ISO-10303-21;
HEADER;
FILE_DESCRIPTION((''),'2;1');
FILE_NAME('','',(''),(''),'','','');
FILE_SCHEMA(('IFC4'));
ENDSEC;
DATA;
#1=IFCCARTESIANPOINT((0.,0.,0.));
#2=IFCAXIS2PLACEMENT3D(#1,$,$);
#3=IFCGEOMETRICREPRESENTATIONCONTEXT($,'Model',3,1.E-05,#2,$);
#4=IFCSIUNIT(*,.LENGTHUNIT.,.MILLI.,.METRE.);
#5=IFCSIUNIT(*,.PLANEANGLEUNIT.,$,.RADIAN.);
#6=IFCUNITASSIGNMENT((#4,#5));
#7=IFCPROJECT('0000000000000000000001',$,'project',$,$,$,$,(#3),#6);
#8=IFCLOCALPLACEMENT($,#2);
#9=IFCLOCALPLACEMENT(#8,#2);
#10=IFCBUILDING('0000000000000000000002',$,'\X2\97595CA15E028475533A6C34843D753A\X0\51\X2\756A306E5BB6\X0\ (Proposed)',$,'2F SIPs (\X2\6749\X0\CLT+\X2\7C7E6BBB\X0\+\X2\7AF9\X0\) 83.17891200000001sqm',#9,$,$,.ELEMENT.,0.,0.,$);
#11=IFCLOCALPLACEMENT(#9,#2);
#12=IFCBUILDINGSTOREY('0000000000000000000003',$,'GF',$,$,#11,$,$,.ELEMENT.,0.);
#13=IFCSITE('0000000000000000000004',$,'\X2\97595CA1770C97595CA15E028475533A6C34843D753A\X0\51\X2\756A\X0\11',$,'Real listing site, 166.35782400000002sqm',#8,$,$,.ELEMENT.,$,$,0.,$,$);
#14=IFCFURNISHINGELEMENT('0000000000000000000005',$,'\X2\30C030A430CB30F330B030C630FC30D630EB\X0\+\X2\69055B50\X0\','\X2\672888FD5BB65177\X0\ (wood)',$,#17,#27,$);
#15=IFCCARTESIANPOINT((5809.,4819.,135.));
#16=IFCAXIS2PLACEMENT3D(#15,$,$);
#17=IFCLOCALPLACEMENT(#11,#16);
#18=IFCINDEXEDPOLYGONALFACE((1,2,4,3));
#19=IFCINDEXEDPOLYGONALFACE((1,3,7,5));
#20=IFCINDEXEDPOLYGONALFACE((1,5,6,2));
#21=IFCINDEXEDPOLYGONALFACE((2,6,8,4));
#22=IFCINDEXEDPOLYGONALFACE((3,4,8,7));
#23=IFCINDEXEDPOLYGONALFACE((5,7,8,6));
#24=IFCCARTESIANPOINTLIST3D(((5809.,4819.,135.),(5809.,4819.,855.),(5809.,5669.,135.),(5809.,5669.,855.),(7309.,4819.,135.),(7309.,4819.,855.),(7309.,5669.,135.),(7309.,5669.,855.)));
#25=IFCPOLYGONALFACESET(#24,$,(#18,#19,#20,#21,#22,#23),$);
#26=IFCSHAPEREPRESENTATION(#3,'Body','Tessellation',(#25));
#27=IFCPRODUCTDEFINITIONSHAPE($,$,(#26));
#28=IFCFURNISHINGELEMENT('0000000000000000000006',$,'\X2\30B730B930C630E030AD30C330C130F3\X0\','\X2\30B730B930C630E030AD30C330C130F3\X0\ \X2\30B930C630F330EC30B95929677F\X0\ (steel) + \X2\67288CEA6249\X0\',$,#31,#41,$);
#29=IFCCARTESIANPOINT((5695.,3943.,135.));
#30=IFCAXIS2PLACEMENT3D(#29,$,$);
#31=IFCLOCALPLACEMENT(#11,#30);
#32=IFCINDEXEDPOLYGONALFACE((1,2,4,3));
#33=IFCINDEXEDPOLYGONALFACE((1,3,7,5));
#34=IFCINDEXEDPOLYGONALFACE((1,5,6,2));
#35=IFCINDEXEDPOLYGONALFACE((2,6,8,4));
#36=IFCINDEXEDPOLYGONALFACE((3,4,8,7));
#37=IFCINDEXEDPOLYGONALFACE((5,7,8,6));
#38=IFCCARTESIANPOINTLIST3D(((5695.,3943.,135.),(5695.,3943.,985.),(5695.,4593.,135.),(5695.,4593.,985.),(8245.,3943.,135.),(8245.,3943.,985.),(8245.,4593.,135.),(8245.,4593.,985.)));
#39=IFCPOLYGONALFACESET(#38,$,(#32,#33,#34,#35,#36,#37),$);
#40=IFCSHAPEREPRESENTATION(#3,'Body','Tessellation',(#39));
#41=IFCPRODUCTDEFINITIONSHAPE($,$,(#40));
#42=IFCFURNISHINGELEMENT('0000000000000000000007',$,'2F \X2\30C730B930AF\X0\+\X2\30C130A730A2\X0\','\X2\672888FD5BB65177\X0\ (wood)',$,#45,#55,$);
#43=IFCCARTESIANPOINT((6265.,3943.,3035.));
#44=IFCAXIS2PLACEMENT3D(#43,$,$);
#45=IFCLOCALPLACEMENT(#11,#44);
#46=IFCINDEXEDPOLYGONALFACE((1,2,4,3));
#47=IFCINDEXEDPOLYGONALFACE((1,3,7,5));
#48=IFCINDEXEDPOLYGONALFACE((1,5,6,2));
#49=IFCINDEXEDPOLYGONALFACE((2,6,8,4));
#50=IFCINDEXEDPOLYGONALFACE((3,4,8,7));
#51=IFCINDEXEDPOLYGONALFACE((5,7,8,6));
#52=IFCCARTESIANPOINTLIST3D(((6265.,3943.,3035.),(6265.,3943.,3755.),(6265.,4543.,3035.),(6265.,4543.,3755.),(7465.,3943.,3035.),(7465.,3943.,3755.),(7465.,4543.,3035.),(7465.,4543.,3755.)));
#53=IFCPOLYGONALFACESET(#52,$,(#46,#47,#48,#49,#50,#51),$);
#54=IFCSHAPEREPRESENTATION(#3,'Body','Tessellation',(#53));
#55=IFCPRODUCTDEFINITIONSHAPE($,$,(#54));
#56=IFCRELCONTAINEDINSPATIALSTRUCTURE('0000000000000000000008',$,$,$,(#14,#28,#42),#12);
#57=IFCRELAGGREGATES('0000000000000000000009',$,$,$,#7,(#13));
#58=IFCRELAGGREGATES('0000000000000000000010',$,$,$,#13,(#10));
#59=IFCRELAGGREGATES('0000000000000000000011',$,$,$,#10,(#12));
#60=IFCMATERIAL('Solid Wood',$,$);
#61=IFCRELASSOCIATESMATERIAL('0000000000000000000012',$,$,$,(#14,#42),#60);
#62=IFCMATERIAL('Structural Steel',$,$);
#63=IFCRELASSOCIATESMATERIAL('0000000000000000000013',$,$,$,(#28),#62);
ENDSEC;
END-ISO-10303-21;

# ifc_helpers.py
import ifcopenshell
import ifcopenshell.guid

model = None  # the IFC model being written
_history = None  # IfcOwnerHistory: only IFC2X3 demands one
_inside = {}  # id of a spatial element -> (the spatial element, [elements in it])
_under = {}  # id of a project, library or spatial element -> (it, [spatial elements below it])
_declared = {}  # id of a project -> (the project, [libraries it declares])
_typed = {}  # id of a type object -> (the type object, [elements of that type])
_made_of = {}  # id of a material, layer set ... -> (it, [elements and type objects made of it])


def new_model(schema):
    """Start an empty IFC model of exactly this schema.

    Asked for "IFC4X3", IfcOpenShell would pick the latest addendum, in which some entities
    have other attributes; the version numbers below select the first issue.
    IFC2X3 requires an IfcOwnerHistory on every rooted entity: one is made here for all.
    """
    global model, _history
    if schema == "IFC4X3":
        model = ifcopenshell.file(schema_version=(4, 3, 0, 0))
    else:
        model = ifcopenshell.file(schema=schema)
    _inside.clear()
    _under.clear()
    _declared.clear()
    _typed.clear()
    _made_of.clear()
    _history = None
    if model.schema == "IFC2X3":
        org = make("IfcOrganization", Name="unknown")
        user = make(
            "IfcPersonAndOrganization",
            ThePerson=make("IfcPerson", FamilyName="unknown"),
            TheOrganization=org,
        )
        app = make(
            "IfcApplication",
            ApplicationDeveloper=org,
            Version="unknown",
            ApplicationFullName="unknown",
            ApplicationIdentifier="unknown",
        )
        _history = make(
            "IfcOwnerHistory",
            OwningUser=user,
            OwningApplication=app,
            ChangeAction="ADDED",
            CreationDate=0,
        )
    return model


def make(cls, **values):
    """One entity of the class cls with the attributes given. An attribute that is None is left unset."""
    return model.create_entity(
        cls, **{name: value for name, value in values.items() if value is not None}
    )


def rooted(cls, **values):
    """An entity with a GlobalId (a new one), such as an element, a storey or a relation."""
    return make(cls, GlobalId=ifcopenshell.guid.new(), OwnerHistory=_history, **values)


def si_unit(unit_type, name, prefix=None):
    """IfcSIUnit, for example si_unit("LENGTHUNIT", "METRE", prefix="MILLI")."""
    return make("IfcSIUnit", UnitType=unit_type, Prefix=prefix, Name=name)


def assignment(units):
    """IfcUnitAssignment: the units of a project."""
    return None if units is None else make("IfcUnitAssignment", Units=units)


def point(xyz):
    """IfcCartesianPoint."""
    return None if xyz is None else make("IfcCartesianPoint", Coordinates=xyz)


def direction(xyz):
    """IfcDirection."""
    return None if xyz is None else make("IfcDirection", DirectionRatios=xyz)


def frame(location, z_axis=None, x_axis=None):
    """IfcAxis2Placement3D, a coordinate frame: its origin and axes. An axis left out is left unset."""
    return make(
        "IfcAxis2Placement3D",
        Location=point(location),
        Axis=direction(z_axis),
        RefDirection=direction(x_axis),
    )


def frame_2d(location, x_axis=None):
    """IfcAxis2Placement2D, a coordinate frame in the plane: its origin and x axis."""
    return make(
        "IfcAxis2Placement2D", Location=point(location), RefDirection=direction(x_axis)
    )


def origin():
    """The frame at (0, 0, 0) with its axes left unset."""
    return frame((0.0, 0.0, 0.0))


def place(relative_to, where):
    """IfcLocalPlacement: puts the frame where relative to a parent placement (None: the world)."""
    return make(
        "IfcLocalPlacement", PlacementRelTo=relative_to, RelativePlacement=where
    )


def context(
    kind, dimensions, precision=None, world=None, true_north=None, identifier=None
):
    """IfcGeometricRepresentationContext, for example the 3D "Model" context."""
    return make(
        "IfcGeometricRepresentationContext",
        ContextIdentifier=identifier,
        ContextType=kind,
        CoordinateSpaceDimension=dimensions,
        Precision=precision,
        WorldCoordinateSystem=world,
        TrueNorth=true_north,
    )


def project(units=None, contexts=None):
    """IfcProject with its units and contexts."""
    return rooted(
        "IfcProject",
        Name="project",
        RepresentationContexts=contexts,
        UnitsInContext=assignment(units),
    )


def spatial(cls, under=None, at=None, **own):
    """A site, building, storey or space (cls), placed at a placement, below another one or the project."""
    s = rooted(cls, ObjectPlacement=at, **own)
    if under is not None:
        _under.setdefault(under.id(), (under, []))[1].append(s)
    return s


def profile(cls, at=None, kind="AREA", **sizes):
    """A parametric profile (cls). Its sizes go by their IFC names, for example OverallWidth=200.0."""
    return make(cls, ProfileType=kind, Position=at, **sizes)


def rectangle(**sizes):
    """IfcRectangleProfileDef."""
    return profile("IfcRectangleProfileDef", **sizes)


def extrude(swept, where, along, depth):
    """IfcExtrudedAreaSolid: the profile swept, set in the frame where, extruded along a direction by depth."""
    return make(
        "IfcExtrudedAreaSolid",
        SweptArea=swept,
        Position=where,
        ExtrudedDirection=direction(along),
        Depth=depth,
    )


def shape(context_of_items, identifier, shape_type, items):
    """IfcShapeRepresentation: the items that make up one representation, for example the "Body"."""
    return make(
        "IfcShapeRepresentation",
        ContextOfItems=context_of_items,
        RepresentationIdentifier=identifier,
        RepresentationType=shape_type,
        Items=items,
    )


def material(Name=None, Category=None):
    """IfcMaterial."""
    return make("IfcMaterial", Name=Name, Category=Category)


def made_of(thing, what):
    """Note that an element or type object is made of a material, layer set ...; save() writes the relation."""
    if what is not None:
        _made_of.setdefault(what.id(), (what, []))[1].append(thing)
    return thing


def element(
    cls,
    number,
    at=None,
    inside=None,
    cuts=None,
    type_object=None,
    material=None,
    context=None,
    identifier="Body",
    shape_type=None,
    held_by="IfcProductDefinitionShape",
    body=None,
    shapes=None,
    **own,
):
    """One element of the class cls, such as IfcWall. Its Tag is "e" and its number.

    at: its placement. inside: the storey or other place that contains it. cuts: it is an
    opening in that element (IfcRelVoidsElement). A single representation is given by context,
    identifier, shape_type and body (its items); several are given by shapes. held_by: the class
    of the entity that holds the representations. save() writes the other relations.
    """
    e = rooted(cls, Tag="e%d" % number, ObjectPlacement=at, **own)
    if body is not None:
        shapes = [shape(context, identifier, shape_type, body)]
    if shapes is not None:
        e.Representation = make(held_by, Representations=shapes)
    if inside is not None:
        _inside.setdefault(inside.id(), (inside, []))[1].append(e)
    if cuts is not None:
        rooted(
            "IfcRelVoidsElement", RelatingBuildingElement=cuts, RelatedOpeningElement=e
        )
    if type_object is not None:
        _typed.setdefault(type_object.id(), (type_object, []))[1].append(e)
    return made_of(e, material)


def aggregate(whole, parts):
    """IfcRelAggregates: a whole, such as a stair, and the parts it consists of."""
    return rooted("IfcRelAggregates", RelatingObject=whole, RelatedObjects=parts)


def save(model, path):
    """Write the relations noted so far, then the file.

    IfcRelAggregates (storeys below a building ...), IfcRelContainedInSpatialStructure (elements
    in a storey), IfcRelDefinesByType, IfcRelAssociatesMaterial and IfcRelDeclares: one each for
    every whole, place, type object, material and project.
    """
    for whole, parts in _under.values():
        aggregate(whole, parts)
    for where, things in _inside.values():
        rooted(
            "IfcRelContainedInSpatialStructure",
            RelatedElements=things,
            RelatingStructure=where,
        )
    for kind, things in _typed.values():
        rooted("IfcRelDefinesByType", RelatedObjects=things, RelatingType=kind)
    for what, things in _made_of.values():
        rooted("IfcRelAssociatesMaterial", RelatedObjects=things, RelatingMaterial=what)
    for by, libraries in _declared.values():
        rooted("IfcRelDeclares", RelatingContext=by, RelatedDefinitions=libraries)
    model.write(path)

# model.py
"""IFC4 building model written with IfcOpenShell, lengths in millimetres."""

from ifc_helpers import new_model, si_unit, frame, frame_2d, origin, place, context, project, spatial, rectangle, extrude, material, element, save


model = new_model("IFC4")

# Units and contexts
model_context = context("Model", 3, precision=1e-05, world=origin())
ifc_project = project(units=[si_unit("LENGTHUNIT", "METRE", prefix="MILLI"), si_unit("PLANEANGLEUNIT", "RADIAN")], contexts=[model_context])

# Site, building, storey
site_placement = place(None, origin())
site = spatial("IfcSite", under=ifc_project, at=site_placement, Name="静岡県静岡市葵区水落町51番11", ObjectType="Real listing site, 166.35782400000002sqm", CompositionType="ELEMENT", RefElevation=0.0)
building_placement = place(site_placement, origin())
building = spatial("IfcBuilding", under=site, at=building_placement, Name="静岡市葵区水落町51番の家 (Proposed)", ObjectType="2F SIPs (杉CLT+籾殻+竹) 83.17891200000001sqm", CompositionType="ELEMENT", ElevationOfRefHeight=0.0, ElevationOfTerrain=0.0)
storey_placement = place(building_placement, origin())
storey = spatial("IfcBuildingStorey", under=building, at=storey_placement, Name="GF", CompositionType="ELEMENT", Elevation=0.0)

# Shared definitions
ifc_material_1 = material(Name="Solid Wood")

# Shared definitions
ifc_material_2 = material(Name="Structural Steel")

# Furnishing elements
furnishing_1_placement = place(storey_placement, frame((5809.0, 4819.0, 135.0)))
element("IfcFurnishingElement", 1, at=furnishing_1_placement, inside=storey, material=ifc_material_1, Name="ダイニングテーブル+椅子", Description="木製家具 (wood)", context=model_context, shape_type="SweptSolid", body=[
    extrude(rectangle(XDim=1500.0, YDim=850.0, at=frame_2d((750.0, 425.0))), frame((5809.0, 4819.0, 135.0)), (0.0, 0.0, 1.0), 720.0),
])
furnishing_2_placement = place(storey_placement, frame((5695.0, 3943.0, 135.0)))
element("IfcFurnishingElement", 2, at=furnishing_2_placement, inside=storey, material=ifc_material_2, Name="システムキッチン", Description="システムキッチン ステンレス天板 (steel) + 木質扉", context=model_context, shape_type="SweptSolid", body=[
    extrude(rectangle(XDim=2550.0, YDim=650.0, at=frame_2d((1275.0, 325.0))), frame((5695.0, 3943.0, 135.0)), (0.0, 0.0, 1.0), 850.0),
])
furnishing_3_placement = place(storey_placement, frame((6265.0, 3943.0, 3035.0)))
element("IfcFurnishingElement", 3, at=furnishing_3_placement, inside=storey, material=ifc_material_1, Name="2F デスク+チェア", Description="木製家具 (wood)", context=model_context, shape_type="SweptSolid", body=[
    extrude(rectangle(XDim=1200.0, YDim=600.0, at=frame_2d((600.0, 300.0))), frame((6265.0, 3943.0, 3035.0)), (0.0, 0.0, 1.0), 720.0),
])

save(model, "model.ifc")
